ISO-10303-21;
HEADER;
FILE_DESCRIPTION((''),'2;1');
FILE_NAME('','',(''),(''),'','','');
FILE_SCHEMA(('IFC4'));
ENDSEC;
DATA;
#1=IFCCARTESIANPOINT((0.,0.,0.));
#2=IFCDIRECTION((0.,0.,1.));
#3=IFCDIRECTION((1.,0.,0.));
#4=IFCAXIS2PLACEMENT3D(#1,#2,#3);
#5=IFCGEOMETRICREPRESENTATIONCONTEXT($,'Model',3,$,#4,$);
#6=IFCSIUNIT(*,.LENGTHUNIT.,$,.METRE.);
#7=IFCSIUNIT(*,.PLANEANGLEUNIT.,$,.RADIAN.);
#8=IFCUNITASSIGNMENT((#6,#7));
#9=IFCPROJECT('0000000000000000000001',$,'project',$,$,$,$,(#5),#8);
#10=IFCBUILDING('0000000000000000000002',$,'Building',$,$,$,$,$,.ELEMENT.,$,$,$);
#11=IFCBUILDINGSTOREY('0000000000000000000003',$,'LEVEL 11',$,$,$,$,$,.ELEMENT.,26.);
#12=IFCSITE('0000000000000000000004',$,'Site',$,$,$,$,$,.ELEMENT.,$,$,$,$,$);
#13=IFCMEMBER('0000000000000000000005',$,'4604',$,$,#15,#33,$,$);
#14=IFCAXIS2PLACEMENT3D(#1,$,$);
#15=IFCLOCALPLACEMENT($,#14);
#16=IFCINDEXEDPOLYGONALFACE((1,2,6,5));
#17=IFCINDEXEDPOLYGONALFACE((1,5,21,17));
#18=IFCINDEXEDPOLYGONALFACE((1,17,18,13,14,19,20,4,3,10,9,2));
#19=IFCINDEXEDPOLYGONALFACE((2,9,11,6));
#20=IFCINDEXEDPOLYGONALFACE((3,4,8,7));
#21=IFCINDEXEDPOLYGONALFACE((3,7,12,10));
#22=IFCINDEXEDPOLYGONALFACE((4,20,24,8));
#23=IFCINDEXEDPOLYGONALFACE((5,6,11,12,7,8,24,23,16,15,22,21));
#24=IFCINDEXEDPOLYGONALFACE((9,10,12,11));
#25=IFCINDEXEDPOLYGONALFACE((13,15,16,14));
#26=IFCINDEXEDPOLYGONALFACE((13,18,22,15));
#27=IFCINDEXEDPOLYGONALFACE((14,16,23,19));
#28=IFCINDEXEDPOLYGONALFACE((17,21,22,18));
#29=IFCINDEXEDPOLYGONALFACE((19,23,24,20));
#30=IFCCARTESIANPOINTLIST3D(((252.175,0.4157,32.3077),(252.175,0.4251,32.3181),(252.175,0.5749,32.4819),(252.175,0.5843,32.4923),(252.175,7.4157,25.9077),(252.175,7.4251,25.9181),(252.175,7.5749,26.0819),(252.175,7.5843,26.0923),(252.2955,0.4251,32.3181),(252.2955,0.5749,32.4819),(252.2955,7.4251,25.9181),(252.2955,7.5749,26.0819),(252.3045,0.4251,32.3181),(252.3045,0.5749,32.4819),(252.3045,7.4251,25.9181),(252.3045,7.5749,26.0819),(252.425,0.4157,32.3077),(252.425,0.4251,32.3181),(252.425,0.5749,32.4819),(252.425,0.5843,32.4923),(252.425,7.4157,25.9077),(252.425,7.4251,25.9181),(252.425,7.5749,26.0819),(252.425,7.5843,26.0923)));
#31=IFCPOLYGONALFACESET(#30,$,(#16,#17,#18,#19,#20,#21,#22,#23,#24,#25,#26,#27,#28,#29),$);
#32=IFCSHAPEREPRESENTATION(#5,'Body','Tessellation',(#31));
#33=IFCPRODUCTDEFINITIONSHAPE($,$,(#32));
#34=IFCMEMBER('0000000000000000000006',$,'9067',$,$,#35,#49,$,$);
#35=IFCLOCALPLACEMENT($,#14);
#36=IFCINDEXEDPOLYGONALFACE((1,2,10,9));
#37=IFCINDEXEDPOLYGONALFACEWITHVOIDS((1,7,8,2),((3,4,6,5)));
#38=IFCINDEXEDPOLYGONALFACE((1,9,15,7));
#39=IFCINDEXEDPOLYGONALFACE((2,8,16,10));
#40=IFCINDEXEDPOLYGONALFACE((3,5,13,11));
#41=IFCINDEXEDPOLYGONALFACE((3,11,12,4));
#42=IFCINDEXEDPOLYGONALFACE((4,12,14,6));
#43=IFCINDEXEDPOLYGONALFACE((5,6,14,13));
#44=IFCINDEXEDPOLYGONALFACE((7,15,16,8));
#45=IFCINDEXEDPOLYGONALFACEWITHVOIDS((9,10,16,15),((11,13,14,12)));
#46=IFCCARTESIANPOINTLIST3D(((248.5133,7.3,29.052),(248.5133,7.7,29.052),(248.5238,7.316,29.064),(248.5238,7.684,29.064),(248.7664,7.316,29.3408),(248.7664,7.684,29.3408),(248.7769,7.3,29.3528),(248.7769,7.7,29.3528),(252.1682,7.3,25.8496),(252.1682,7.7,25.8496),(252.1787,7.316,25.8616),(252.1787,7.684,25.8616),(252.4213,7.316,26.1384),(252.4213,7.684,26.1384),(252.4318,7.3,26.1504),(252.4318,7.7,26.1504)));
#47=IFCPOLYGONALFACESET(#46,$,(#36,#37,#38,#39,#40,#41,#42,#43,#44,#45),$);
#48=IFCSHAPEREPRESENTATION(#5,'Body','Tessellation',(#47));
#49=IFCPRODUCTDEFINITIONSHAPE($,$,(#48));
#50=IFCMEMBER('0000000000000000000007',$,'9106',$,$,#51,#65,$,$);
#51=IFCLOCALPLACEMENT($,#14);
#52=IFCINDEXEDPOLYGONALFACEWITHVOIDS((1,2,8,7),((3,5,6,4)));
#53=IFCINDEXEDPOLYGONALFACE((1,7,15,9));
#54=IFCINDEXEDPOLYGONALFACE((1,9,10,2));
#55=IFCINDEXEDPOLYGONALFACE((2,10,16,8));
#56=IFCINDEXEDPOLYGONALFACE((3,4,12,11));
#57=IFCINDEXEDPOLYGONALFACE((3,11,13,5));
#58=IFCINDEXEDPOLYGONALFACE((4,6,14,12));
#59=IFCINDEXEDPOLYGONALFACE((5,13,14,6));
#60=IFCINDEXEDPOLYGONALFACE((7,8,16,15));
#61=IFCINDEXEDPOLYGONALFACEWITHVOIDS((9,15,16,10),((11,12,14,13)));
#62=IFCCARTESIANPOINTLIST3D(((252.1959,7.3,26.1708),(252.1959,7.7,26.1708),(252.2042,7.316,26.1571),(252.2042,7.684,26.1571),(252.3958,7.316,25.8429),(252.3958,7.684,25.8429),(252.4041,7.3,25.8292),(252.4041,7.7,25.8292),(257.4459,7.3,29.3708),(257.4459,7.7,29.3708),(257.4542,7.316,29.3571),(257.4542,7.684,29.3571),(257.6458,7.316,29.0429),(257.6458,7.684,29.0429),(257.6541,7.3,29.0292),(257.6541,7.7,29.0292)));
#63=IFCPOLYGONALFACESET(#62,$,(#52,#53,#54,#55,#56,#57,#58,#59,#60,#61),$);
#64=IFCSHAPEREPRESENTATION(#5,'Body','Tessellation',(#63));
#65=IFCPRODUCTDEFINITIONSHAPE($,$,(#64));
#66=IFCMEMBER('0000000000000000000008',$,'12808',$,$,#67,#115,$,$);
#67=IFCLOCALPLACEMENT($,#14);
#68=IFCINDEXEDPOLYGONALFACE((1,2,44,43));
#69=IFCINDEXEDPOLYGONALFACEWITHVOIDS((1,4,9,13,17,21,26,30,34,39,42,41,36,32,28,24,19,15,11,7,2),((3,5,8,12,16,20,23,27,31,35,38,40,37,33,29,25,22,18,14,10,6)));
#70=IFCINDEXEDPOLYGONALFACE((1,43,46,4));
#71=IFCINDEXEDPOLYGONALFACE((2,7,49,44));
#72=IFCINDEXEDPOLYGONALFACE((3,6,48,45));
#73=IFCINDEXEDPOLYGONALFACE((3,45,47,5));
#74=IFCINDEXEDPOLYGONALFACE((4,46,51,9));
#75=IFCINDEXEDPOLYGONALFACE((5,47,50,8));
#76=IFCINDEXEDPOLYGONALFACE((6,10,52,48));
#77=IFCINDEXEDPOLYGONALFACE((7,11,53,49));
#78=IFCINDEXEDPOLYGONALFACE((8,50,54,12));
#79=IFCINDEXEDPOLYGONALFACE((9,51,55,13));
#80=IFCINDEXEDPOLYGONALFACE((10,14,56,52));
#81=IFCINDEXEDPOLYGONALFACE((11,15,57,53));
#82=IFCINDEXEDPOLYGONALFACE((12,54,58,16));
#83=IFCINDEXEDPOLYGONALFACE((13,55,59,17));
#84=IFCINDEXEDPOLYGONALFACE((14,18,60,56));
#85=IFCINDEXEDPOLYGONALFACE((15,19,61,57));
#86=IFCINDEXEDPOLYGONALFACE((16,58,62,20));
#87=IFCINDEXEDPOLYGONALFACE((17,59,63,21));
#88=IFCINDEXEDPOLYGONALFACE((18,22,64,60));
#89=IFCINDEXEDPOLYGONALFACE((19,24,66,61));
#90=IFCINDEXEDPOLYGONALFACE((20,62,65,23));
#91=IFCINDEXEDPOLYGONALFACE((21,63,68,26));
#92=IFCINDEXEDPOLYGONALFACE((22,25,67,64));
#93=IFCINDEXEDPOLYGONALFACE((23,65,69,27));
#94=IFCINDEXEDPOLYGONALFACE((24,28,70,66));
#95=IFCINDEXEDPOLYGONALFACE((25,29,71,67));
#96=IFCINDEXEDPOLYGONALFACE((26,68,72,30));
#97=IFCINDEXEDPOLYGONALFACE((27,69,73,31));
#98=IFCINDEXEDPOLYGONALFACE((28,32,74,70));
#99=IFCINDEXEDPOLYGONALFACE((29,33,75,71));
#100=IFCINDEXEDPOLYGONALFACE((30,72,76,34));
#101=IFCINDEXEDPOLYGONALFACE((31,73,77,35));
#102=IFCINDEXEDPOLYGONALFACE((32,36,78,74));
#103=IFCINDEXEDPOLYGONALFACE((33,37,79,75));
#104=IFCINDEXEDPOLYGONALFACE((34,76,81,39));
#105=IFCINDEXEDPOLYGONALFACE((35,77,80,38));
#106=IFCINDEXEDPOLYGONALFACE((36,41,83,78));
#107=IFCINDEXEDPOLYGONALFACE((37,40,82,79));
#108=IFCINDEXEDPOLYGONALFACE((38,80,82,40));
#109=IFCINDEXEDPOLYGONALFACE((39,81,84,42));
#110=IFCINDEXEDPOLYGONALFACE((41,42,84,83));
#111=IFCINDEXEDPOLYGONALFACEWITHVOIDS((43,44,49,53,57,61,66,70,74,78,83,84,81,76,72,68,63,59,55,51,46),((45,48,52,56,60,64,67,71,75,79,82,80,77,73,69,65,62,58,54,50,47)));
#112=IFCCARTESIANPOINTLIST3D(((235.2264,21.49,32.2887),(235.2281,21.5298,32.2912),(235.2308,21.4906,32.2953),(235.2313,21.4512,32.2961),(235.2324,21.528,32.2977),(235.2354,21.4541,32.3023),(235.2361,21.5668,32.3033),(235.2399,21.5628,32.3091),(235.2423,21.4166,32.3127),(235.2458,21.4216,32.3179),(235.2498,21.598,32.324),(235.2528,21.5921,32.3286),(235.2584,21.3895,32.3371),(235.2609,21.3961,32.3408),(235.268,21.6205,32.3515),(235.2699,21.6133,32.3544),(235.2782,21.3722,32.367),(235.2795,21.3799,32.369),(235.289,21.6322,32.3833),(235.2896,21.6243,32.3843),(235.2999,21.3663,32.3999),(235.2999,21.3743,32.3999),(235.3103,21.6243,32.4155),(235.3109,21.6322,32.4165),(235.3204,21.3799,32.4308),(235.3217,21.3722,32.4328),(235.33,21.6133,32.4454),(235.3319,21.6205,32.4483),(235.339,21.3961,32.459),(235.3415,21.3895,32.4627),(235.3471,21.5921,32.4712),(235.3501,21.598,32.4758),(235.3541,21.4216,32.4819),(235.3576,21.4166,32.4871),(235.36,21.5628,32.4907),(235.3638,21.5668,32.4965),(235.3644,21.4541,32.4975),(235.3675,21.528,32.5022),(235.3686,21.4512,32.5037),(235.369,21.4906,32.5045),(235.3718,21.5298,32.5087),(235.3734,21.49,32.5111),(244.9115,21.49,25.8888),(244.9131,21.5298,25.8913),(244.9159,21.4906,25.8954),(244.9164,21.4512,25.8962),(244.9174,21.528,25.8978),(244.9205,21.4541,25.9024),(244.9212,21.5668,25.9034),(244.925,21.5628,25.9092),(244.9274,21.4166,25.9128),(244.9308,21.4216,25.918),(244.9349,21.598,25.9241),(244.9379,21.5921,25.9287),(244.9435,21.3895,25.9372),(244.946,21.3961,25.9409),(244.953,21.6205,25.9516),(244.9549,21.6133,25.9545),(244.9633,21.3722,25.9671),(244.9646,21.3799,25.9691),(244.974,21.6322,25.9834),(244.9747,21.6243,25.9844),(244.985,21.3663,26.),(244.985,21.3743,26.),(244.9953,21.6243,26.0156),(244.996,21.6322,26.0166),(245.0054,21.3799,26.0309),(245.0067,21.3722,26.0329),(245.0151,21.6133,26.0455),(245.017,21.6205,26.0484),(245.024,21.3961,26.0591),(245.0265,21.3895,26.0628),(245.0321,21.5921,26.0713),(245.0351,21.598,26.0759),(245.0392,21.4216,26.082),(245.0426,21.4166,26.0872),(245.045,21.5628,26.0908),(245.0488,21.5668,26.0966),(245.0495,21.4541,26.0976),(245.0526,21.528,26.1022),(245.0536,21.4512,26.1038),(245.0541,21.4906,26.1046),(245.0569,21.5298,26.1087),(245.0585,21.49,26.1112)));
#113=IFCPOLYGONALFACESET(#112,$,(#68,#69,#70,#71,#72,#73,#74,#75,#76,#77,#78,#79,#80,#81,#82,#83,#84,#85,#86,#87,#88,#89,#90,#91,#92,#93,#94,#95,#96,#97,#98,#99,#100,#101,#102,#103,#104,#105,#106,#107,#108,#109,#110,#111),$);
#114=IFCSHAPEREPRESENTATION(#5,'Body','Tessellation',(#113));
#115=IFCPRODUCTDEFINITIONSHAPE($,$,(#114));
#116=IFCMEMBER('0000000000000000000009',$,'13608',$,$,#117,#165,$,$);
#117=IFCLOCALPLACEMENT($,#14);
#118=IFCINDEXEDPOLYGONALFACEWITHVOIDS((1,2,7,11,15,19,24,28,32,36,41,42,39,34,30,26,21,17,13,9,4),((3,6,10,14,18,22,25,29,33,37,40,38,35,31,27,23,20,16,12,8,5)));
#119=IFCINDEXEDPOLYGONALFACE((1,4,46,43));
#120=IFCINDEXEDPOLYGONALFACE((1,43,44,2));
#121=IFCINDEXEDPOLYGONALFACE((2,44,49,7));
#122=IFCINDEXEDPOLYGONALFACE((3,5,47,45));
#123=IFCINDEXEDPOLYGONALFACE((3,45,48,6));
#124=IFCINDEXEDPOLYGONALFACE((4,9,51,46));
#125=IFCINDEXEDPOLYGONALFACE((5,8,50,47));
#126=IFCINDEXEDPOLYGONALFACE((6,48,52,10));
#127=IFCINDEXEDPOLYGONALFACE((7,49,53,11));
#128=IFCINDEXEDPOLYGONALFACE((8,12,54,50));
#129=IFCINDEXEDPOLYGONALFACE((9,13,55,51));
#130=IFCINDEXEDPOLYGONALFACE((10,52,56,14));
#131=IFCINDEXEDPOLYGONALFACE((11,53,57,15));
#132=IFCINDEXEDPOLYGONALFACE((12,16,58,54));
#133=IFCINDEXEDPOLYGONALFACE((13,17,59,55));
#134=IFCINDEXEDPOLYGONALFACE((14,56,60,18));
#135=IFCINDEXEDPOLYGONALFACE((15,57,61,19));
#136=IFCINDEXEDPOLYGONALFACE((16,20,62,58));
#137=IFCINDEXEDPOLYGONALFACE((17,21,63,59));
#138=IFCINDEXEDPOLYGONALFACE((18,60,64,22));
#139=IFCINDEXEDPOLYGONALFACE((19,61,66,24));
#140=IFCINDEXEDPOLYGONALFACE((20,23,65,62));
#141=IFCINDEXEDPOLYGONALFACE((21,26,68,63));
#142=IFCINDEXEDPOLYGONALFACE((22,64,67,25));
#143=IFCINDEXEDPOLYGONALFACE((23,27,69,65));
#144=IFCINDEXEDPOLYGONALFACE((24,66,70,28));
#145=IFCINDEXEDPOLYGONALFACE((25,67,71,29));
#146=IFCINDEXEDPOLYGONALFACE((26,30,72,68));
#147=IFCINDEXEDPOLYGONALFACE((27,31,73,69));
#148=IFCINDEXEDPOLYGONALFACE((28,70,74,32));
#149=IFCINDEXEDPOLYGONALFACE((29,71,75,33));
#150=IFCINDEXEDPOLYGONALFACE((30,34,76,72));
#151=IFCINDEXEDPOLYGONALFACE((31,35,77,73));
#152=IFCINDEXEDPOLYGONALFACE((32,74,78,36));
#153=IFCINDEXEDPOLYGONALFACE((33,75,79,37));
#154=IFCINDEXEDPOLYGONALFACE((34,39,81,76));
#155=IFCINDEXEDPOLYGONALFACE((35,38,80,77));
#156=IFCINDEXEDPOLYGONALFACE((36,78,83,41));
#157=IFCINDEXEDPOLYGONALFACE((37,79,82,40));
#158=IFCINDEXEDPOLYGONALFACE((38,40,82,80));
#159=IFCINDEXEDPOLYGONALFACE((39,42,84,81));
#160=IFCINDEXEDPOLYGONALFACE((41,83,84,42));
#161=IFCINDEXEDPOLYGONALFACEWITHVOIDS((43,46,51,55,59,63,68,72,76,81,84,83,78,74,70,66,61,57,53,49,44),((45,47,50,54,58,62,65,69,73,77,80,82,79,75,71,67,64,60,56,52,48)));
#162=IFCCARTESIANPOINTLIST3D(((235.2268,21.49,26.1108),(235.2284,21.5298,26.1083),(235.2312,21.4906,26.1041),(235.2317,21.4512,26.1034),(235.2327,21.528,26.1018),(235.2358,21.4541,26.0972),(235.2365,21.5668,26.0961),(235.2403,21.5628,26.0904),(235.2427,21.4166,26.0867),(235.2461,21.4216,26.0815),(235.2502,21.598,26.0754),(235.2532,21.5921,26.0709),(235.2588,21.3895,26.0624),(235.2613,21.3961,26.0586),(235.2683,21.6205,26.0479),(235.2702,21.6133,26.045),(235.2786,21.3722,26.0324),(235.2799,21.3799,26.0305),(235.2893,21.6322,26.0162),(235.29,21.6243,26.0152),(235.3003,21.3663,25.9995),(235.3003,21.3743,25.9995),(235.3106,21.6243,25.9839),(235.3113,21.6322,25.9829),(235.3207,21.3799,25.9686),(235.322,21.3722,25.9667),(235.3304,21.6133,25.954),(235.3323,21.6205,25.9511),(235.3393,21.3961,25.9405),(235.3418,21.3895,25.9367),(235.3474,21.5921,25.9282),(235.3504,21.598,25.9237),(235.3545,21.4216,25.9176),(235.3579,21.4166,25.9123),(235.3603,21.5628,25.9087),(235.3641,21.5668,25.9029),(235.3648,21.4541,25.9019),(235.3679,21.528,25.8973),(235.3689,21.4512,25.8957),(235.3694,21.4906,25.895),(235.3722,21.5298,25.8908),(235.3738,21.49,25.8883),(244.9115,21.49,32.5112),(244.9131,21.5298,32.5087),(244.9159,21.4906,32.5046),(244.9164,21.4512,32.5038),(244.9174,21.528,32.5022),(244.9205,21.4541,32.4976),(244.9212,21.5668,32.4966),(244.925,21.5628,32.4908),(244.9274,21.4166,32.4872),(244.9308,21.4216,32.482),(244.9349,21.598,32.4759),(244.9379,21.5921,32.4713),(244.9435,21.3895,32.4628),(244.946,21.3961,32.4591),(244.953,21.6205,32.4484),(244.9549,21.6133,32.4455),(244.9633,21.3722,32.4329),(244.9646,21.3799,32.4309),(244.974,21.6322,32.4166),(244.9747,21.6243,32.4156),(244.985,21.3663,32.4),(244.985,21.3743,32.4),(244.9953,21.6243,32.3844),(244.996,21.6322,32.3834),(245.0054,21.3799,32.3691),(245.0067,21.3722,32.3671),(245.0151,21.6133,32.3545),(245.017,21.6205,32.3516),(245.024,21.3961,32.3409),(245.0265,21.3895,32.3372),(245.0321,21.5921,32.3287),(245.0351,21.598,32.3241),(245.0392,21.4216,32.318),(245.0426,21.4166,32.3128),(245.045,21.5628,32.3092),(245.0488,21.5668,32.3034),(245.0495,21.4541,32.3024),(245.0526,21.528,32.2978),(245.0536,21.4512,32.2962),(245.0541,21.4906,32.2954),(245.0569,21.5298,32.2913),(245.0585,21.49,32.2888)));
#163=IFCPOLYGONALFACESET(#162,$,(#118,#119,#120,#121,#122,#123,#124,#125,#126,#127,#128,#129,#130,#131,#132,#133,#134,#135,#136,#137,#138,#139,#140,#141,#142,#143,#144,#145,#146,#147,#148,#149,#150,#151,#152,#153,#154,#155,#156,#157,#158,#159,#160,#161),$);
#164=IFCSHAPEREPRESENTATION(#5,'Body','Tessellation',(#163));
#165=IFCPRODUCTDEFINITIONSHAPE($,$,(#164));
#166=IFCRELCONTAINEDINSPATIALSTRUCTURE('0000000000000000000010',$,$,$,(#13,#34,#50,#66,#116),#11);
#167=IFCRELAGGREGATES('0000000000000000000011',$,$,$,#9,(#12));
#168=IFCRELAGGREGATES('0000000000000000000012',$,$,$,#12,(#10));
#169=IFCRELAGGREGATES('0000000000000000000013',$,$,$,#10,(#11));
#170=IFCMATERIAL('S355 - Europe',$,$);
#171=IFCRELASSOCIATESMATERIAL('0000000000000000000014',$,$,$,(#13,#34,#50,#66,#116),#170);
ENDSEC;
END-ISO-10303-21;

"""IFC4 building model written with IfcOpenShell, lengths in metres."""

from ifc_helpers import new_model, si_unit, frame, origin_with_axes, origin_2d_with_axis, place, context, project, spatial, hollow_rectangle, hollow_circle, i_section, extrude, material, material_profile, profile_set, profile_usage, element, save


model = new_model("IFC4")

# Units and contexts
model_context = context("Model", 3, world=origin_with_axes())
ifc_project = project(units=[si_unit("LENGTHUNIT", "METRE"), si_unit("PLANEANGLEUNIT", "RADIAN")], contexts=[model_context])

# Site, building, storey
site = spatial("IfcSite", under=ifc_project, Name="Site", CompositionType="ELEMENT")
building = spatial("IfcBuilding", under=site, Name="Building", CompositionType="ELEMENT")
storey = spatial("IfcBuildingStorey", under=building, Name="LEVEL 11", CompositionType="ELEMENT", Elevation=26.0)

# Shared definitions
ifc_material = material(Name="S355 - Europe")

# Members
ifc_material_profile_1 = material_profile(ifc_material, i_section(OverallWidth=0.25, OverallDepth=0.25, WebThickness=0.009, FlangeThickness=0.014, at=origin_2d_with_axis()))
ifc_profile_set_1 = profile_set([ifc_material_profile_1])
ifc_profile_usage_1 = profile_usage(ifc_profile_set_1, cardinal=10)
member_1_placement = place(None, frame((252.3, 7.5, 26.0), z_axis=(0.0, -0.738029, 0.674769), x_axis=(1.0, 0.0, 0.0)))
element("IfcMember", 1, at=member_1_placement, inside=storey, material=ifc_profile_usage_1, Name="4604", context=model_context, shape_type="SweptSolid", body=[
    extrude(i_section(OverallWidth=0.25, OverallDepth=0.25, WebThickness=0.009, FlangeThickness=0.014, at=origin_2d_with_axis()), origin_with_axes(), (0.0, 0.0, 1.0), 9.4847),
])
ifc_material_profile_2 = material_profile(ifc_material, hollow_rectangle(XDim=0.4, YDim=0.4, WallThickness=0.016, at=origin_2d_with_axis()))
ifc_profile_set_2 = profile_set([ifc_material_profile_2])
ifc_profile_usage_2 = profile_usage(ifc_profile_set_2, cardinal=10)
member_2_placement = place(None, frame((252.3, 7.5, 26.0), z_axis=(-0.752133, 0.0, 0.659012), x_axis=(0.0, -1.0, 0.0)))
element("IfcMember", 2, at=member_2_placement, inside=storey, material=ifc_profile_usage_2, Name="9067", context=model_context, shape_type="SweptSolid", body=[
    extrude(hollow_rectangle(XDim=0.4, YDim=0.4, WallThickness=0.016, at=origin_2d_with_axis()), origin_with_axes(), (0.0, 0.0, 1.0), 4.8594),
])
ifc_material_profile_3 = material_profile(ifc_material, hollow_rectangle(XDim=0.4, YDim=0.4, WallThickness=0.016, at=origin_2d_with_axis()))
ifc_profile_set_3 = profile_set([ifc_material_profile_3])
ifc_profile_usage_3 = profile_usage(ifc_profile_set_3, cardinal=10)
member_3_placement = place(None, frame((257.55, 7.5, 29.2), z_axis=(-0.853884, 0.0, -0.520463), x_axis=(0.0, -1.0, 0.0)))
element("IfcMember", 3, at=member_3_placement, inside=storey, material=ifc_profile_usage_3, Name="9106", context=model_context, shape_type="SweptSolid", body=[
    extrude(hollow_rectangle(XDim=0.4, YDim=0.4, WallThickness=0.016, at=origin_2d_with_axis()), origin_with_axes(), (0.0, 0.0, 1.0), 6.1484),
])
ifc_material_profile_4 = material_profile(ifc_material, hollow_circle(Radius=0.1337, WallThickness=0.008, at=origin_2d_with_axis()))
ifc_profile_set_4 = profile_set([ifc_material_profile_4])
ifc_profile_usage_4 = profile_usage(ifc_profile_set_4, cardinal=10)
member_4_placement = place(None, frame((244.985, 21.5, 26.0), z_axis=(-0.834302, 0.0, 0.551308), x_axis=(0.0, -1.0, 0.0)))
element("IfcMember", 4, at=member_4_placement, inside=storey, material=ifc_profile_usage_4, Name="12808", context=model_context, shape_type="SweptSolid", body=[
    extrude(hollow_circle(Radius=0.1337, WallThickness=0.008, at=origin_2d_with_axis()), origin_with_axes(), (0.0, 0.0, 1.0), 11.6086),
])
ifc_material_profile_5 = material_profile(ifc_material, hollow_circle(Radius=0.1337, WallThickness=0.008, at=origin_2d_with_axis()))
ifc_profile_set_5 = profile_set([ifc_material_profile_5])
ifc_profile_usage_5 = profile_usage(ifc_profile_set_5, cardinal=10)
member_5_placement = place(None, frame((244.985, 21.5, 32.4), z_axis=(-0.83427, 0.0, -0.551356), x_axis=(0.0, -1.0, 0.0)))
element("IfcMember", 5, at=member_5_placement, inside=storey, material=ifc_profile_usage_5, Name="13608", context=model_context, shape_type="SweptSolid", body=[
    extrude(hollow_circle(Radius=0.1337, WallThickness=0.008, at=origin_2d_with_axis()), origin_with_axes(), (0.0, 0.0, 1.0), 11.6086),
])

save(model, "model.ifc")
